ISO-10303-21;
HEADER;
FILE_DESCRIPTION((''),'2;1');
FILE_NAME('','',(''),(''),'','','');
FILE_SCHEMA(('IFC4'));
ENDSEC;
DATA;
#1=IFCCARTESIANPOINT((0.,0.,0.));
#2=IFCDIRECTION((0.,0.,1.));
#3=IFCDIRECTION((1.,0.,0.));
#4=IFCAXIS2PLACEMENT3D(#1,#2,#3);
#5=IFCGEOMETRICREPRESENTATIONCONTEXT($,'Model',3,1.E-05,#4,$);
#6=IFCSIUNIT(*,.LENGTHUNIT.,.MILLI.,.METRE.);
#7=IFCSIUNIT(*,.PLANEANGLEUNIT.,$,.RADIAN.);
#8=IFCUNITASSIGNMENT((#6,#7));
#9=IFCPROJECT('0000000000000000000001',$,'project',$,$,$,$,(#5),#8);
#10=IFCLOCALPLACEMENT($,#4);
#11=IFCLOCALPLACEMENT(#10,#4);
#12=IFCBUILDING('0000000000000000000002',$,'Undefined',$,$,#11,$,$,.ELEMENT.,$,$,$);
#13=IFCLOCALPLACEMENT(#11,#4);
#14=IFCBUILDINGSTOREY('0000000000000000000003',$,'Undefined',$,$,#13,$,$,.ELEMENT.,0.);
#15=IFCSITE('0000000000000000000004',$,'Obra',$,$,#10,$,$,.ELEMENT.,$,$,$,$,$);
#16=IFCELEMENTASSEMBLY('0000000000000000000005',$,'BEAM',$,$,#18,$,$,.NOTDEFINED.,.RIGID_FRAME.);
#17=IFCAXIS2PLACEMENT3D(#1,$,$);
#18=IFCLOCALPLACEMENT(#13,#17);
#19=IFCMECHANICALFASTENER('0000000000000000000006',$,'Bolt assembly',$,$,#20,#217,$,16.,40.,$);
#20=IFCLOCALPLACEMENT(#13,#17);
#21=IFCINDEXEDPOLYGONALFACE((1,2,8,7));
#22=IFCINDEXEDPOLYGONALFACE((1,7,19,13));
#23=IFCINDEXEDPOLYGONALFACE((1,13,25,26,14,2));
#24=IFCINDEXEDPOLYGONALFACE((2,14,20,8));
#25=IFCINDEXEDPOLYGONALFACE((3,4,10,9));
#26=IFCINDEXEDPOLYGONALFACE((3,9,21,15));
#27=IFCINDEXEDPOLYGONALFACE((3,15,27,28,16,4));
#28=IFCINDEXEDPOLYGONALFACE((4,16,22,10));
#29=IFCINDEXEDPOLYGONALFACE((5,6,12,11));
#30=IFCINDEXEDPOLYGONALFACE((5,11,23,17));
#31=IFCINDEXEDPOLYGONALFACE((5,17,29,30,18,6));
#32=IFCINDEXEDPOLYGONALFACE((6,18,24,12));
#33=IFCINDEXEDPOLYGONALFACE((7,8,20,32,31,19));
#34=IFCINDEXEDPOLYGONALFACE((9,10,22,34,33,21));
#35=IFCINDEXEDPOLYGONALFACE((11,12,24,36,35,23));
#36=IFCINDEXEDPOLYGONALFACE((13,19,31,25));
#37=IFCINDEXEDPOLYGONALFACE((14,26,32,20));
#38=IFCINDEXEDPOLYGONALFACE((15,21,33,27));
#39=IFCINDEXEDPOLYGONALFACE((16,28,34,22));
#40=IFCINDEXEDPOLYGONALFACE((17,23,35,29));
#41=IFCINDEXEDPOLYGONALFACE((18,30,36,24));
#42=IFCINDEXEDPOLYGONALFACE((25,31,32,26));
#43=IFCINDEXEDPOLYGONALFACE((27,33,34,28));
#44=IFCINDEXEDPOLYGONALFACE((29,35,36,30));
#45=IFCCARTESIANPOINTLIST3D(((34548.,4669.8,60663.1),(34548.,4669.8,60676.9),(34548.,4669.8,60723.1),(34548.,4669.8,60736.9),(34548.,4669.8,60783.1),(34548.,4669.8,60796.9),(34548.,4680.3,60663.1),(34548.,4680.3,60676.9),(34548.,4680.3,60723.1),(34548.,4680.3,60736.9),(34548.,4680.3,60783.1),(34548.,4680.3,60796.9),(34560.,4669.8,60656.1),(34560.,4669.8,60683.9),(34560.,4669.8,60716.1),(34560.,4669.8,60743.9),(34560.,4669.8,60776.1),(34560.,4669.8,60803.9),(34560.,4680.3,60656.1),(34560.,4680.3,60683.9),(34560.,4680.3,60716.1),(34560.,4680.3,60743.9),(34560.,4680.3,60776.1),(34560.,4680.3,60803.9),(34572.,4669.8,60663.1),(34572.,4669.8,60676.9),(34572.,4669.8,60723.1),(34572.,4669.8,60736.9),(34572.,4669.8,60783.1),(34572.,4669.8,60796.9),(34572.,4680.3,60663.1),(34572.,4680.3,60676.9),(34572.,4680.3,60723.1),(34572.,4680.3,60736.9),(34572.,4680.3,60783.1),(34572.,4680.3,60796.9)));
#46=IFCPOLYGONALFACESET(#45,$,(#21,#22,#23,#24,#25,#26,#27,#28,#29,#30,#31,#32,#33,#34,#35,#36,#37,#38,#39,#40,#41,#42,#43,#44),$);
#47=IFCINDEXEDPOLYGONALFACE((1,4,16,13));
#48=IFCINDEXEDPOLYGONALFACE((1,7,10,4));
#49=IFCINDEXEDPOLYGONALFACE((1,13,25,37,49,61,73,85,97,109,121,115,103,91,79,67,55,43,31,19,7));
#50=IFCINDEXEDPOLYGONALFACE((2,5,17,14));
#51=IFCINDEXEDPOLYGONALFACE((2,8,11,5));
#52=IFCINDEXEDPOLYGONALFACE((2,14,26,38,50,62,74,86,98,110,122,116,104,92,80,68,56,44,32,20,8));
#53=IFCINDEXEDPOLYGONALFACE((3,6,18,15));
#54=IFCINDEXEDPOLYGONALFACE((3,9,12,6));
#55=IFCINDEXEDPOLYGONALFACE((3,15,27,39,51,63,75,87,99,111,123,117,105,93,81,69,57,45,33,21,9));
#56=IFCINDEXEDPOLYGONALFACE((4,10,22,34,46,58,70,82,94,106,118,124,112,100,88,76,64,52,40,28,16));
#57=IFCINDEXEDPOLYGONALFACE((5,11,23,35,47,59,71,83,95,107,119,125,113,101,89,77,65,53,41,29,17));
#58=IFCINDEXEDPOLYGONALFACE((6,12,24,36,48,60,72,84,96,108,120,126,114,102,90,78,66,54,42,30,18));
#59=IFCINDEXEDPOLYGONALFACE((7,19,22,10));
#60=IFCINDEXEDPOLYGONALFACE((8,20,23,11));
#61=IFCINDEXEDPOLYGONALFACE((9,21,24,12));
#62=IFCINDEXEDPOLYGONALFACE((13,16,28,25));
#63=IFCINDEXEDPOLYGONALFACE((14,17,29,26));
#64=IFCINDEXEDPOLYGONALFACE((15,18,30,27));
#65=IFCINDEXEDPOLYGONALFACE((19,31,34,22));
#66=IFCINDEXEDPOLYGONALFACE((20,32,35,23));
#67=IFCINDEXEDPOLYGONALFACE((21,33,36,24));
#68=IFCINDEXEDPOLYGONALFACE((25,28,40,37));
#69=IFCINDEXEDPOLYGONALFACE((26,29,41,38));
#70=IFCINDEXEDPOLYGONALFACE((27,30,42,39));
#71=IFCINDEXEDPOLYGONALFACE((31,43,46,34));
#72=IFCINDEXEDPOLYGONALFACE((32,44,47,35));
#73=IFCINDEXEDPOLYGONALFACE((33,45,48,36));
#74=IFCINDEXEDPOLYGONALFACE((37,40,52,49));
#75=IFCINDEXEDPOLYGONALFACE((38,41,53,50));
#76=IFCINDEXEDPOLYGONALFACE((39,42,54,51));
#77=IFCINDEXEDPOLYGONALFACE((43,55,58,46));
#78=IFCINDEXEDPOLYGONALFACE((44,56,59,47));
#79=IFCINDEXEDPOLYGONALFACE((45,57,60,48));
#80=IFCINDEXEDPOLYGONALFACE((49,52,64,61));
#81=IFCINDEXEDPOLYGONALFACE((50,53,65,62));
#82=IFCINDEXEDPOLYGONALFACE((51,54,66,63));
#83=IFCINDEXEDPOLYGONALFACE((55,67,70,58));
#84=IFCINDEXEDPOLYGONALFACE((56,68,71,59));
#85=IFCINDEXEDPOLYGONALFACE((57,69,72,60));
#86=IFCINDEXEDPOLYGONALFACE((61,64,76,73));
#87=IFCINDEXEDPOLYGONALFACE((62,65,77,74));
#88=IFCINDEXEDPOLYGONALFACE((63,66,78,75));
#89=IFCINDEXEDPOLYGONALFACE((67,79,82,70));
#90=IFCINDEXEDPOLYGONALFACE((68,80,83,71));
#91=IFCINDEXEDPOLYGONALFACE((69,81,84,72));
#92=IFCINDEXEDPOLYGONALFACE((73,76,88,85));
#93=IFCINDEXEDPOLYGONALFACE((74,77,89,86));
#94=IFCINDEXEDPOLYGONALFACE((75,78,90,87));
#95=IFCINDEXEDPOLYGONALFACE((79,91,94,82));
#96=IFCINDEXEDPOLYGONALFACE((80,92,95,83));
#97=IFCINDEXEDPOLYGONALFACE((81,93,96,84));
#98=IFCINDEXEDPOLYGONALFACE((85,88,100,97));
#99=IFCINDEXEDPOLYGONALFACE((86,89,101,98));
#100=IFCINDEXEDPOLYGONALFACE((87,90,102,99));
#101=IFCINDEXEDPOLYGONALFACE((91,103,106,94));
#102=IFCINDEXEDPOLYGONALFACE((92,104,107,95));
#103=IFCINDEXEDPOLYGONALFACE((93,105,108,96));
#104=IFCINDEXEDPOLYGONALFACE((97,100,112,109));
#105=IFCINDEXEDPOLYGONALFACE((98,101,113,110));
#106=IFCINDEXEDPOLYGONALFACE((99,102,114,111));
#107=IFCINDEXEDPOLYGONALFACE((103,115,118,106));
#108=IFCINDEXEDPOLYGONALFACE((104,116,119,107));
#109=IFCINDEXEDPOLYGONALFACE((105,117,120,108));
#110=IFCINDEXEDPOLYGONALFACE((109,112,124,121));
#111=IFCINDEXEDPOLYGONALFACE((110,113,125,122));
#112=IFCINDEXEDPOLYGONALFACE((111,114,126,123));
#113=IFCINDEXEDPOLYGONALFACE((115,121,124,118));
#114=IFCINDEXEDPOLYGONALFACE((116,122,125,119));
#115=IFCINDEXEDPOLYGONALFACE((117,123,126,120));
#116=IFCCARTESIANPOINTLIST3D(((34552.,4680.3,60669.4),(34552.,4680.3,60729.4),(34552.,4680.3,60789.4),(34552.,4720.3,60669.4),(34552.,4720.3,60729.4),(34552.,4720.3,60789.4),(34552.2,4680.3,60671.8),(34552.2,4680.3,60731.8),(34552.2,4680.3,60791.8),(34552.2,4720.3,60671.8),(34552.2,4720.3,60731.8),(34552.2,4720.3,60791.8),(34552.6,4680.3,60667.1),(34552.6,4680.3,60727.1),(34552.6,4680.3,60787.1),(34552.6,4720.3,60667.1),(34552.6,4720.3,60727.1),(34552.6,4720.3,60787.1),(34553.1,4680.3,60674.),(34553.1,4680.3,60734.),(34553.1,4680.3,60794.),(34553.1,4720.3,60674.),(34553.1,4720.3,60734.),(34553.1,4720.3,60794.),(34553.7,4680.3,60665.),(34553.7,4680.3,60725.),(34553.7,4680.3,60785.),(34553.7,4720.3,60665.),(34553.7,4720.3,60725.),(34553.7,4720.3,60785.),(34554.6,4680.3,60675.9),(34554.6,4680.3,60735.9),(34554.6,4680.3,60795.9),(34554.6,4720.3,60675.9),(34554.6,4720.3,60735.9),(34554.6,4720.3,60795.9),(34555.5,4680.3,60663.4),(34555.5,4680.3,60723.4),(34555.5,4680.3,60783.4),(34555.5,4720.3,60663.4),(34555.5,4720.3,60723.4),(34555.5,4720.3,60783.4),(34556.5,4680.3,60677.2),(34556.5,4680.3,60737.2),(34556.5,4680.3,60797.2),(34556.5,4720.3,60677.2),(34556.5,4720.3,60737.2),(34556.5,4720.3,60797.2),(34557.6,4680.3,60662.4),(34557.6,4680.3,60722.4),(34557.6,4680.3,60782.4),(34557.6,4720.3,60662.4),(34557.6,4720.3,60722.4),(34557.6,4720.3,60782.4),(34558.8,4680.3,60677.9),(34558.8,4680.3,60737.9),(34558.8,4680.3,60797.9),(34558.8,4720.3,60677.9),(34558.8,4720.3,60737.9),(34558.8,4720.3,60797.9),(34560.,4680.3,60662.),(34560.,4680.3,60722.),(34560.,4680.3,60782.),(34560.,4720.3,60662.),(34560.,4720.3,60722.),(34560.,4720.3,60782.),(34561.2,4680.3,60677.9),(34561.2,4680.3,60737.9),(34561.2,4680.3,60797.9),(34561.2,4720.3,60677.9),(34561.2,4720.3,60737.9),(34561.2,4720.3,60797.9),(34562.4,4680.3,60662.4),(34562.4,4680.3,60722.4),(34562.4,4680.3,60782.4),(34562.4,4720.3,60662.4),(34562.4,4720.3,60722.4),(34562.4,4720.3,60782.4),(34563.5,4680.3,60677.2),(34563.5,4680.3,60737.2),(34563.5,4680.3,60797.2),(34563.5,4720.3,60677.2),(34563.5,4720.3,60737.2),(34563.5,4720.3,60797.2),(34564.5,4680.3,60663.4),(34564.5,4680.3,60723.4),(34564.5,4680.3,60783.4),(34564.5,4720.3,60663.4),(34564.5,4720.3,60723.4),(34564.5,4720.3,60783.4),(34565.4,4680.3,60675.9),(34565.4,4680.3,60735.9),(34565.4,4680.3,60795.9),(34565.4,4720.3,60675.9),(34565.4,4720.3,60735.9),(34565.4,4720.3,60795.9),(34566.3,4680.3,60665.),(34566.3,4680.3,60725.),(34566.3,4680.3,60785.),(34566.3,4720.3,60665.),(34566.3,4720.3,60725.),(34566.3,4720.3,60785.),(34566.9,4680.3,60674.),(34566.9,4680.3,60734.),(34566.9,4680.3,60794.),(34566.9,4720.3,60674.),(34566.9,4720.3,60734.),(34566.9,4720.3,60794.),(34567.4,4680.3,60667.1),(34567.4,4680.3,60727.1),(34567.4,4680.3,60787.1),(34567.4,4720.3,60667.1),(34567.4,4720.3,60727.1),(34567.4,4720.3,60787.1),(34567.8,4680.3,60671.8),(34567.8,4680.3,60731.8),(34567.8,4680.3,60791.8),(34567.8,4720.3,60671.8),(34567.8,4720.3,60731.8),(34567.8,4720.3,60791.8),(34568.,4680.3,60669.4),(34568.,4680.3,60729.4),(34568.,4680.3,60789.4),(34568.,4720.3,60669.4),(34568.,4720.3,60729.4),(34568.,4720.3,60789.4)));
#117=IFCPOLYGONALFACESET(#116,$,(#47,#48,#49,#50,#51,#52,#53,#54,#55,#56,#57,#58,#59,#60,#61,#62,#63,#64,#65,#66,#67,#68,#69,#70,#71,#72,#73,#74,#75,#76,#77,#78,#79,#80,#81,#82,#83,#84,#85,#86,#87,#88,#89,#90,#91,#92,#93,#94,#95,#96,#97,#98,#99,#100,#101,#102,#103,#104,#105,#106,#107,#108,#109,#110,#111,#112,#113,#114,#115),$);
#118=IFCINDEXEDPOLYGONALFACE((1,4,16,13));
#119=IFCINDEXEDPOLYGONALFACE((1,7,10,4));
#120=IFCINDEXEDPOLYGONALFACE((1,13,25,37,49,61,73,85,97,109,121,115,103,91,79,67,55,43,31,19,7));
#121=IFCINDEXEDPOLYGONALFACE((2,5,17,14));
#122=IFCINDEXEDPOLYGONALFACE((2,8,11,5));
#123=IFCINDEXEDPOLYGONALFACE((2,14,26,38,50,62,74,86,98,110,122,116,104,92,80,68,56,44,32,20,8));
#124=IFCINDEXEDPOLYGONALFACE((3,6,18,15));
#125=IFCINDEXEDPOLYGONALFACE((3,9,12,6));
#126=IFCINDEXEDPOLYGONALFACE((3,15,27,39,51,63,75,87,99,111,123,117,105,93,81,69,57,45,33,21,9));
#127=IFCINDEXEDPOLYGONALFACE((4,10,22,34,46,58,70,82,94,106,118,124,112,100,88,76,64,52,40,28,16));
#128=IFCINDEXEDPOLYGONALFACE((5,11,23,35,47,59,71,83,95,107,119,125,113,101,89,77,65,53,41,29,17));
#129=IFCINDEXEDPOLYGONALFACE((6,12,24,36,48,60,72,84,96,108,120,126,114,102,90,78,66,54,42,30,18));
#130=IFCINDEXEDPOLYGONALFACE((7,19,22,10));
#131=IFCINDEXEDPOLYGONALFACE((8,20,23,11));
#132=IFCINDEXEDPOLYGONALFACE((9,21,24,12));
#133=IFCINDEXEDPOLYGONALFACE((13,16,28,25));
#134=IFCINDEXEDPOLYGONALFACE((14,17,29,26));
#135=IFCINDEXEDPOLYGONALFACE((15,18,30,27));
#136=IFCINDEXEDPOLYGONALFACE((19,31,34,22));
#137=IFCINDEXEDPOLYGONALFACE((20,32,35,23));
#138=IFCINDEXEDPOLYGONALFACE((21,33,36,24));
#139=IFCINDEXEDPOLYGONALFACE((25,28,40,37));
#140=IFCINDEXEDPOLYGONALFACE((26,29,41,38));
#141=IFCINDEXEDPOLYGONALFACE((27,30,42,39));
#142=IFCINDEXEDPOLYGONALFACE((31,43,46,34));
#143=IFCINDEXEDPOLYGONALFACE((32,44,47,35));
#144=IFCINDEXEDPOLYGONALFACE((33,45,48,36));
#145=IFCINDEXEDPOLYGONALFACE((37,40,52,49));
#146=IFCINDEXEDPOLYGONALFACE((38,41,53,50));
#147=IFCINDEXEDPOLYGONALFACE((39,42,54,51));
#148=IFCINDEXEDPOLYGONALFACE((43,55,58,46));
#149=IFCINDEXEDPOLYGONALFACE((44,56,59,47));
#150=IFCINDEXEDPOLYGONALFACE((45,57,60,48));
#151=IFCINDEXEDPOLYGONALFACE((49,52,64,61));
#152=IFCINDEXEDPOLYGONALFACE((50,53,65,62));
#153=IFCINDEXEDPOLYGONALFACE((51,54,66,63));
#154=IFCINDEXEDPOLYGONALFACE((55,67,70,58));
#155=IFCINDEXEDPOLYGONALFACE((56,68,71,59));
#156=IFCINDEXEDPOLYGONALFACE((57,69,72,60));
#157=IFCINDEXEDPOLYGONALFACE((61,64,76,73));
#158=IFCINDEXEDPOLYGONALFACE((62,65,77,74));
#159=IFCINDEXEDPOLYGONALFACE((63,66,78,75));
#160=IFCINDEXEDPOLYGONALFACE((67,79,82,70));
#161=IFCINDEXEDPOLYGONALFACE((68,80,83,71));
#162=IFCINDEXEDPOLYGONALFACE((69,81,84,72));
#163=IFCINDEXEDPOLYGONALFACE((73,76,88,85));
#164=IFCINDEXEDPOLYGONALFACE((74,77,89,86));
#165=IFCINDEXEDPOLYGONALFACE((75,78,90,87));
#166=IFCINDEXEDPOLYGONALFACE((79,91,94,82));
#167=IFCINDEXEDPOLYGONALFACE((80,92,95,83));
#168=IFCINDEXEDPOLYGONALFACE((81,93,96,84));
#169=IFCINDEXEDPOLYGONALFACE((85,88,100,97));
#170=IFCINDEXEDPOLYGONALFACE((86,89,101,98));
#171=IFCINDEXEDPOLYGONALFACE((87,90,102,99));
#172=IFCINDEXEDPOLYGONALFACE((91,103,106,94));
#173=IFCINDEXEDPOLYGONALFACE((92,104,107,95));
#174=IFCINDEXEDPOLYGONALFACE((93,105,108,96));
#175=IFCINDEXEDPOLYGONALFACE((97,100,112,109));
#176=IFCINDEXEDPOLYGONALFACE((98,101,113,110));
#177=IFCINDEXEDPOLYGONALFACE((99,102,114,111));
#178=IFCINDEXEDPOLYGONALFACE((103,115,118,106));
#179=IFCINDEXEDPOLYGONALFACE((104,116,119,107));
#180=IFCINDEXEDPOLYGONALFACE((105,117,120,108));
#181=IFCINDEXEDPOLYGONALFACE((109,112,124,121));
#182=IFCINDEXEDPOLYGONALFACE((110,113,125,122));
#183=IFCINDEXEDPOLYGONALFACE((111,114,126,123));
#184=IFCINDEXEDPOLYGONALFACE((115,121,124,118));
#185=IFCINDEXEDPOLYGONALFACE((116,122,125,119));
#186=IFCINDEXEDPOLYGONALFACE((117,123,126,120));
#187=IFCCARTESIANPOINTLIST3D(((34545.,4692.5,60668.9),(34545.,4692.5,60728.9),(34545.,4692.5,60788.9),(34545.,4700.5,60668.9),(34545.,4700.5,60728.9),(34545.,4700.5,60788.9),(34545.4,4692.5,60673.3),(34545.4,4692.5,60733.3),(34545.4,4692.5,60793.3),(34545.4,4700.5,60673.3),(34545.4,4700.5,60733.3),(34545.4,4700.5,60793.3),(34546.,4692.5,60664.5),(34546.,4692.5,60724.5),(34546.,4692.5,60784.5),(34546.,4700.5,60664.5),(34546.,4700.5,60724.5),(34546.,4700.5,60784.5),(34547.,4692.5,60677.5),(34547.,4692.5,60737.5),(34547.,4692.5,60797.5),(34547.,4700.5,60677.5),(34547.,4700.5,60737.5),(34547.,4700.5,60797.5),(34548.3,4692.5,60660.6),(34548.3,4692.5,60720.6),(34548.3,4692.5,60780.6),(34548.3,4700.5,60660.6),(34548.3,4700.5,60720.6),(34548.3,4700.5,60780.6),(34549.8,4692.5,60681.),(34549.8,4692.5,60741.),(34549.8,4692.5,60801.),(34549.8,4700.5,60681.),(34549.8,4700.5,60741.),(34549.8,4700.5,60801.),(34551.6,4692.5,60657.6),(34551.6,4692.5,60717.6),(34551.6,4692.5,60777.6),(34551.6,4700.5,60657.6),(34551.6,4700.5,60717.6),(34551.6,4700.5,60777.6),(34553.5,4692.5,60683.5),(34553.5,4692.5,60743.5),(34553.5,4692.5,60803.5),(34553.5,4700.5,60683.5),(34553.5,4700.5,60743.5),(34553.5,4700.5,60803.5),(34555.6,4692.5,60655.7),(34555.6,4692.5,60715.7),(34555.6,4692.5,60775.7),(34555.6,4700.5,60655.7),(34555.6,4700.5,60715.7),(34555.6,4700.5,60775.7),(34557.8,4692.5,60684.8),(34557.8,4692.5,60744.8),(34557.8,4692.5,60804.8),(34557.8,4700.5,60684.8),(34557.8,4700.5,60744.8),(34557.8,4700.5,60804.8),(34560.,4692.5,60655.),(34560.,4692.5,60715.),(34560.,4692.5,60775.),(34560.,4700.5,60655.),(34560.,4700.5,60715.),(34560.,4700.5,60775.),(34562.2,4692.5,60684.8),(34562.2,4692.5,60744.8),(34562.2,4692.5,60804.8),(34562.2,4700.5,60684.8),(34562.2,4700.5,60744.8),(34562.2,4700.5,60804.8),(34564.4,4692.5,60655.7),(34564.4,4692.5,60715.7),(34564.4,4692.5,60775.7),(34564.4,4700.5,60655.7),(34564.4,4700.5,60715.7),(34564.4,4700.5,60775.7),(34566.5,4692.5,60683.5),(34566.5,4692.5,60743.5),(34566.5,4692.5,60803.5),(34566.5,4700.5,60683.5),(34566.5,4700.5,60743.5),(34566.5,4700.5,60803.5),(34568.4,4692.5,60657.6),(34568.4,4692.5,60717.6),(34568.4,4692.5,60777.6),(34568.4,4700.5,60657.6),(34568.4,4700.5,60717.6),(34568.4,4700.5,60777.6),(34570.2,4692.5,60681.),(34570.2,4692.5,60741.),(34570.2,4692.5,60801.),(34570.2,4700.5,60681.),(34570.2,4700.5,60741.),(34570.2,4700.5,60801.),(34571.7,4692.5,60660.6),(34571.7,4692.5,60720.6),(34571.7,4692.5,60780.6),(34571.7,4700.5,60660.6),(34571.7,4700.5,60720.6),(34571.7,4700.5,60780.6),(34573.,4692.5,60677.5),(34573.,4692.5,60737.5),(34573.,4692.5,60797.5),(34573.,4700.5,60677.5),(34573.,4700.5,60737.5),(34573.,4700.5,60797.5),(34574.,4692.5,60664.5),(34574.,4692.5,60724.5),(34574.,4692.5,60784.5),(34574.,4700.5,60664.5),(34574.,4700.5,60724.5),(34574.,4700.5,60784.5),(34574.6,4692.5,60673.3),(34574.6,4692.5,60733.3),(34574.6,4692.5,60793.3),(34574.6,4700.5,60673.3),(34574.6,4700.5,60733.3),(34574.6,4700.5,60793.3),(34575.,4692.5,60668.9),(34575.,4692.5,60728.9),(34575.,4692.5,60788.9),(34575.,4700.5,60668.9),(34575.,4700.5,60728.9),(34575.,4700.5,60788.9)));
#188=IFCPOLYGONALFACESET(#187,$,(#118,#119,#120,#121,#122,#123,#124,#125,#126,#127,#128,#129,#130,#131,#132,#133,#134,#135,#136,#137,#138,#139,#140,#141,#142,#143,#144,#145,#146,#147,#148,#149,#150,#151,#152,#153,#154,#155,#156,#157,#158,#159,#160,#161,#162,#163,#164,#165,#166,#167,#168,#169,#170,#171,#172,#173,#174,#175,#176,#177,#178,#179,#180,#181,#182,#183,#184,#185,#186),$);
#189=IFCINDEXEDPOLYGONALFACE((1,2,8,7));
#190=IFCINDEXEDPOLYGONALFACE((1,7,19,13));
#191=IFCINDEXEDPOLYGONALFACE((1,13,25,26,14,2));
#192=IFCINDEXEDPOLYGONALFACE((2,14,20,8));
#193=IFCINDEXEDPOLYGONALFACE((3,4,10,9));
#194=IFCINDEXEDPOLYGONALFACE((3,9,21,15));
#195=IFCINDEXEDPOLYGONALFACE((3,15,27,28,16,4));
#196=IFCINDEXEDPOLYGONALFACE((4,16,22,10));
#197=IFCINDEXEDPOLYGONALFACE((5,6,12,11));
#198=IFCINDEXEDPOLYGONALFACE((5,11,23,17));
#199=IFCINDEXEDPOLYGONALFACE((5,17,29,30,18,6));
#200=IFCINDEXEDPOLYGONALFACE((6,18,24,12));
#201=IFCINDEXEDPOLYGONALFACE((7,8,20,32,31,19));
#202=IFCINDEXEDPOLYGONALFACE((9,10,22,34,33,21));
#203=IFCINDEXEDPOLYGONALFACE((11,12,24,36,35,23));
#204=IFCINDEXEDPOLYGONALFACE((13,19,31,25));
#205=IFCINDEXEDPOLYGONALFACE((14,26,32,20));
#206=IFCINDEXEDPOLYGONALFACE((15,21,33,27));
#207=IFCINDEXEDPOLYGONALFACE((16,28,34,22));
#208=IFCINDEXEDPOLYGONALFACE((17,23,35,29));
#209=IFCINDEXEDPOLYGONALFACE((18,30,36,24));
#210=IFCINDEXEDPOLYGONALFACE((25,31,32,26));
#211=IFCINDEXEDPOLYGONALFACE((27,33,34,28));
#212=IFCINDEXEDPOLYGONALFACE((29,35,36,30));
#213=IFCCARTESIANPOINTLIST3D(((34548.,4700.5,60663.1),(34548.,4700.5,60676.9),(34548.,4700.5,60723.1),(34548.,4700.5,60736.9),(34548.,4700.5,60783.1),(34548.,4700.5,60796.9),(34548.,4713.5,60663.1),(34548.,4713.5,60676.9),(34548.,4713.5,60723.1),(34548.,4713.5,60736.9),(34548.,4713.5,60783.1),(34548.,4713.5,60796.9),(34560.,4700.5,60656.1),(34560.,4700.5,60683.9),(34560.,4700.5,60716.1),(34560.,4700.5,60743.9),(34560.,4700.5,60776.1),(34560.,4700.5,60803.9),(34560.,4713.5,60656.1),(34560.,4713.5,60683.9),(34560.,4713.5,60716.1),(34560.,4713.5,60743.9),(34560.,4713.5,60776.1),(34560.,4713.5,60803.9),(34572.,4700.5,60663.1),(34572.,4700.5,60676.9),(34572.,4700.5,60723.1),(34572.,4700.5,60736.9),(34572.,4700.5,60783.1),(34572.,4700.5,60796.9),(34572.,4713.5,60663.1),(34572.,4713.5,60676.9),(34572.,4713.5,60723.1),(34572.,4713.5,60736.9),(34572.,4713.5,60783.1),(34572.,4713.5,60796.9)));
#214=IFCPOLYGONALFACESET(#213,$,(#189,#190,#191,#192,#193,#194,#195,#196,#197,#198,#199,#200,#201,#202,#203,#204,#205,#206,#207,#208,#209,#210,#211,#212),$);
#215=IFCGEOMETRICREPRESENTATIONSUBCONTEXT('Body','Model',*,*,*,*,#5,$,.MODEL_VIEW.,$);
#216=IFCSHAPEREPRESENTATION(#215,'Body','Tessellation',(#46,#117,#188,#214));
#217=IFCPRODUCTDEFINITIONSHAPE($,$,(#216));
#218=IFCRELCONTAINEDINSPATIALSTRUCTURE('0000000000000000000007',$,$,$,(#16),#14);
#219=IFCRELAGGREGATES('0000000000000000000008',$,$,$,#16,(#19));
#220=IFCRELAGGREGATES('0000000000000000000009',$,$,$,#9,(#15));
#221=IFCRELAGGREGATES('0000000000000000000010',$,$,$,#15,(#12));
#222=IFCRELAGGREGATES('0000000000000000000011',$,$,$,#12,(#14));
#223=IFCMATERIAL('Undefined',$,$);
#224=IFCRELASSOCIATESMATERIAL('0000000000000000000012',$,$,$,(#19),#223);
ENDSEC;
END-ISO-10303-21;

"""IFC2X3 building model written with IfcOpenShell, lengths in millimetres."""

from ifc_helpers import new_model, si_unit, frame, origin_with_axes, origin_2d_with_axis, place, context, subcontext, project, spatial, polyline, circle, outline, extrude, source, transform, mapped, material, element, aggregate, save


model = new_model("IFC2X3")

# Units and contexts
model_context = context("Model", 3, precision=1e-05, world=origin_with_axes())
body_context = subcontext(model_context, "Body", "Model", "MODEL_VIEW")
ifc_project = project(units=[si_unit("LENGTHUNIT", "METRE", prefix="MILLI"), si_unit("PLANEANGLEUNIT", "RADIAN")], contexts=[model_context])

# Site, building, storey
site_placement = place(None, origin_with_axes())
site = spatial("IfcSite", under=ifc_project, at=site_placement, Name="Obra", CompositionType="ELEMENT")
building_placement = place(site_placement, origin_with_axes())
building = spatial("IfcBuilding", under=site, at=building_placement, Name="Undefined", CompositionType="ELEMENT")
storey_placement = place(building_placement, origin_with_axes())
storey = spatial("IfcBuildingStorey", under=building, at=storey_placement, Name="Undefined", CompositionType="ELEMENT", Elevation=0.0)

# Shared definitions
ifc_material_1 = material(Name="Undefined")

# Element assembly, mechanical fastener
assembly_1_placement = place(storey_placement, origin_with_axes())
assembly_1 = element("IfcElementAssembly", 1, at=assembly_1_placement, inside=storey, Name="BEAM", AssemblyPlace="NOTDEFINED", PredefinedType="RIGID_FRAME")
shared_shape_1 = source(origin_with_axes(), body_context, "Body", "SweptSolid", [
    extrude(outline(polyline([(13.9, 0.0), (6.9, 12.0), (-6.9, 12.0), (-13.9, 0.0), (-6.9, -12.0), (6.9, -12.0), (13.9, 0.0)])), frame((0.0, -19.7, 0.0), z_axis=(0.0, 1.0, 0.0), x_axis=(1.0, 0.0, 0.0)), (0.0, 0.0, 1.0), 10.6),
    extrude(circle(Radius=8.0, at=origin_2d_with_axis()), frame((0.0, -9.1, 0.0), z_axis=(0.0, 1.0, 0.0), x_axis=(1.0, 0.0, 0.0)), (0.0, 0.0, 1.0), 40.0),
    extrude(circle(Radius=15.0, at=origin_2d_with_axis()), frame((0.0, 3.1, 0.0), z_axis=(0.0, 1.0, 0.0), x_axis=(1.0, 0.0, 0.0)), (0.0, 0.0, 1.0), 8.0),
    extrude(outline(polyline([(13.9, 0.0), (6.9, 12.0), (-6.9, 12.0), (-13.9, 0.0), (-6.9, -12.0), (6.9, -12.0), (13.9, 0.0)])), frame((0.0, 11.1, 0.0), z_axis=(0.0, 1.0, 0.0), x_axis=(1.0, 0.0, 0.0)), (0.0, 0.0, 1.0), 13.0),
])
mechanical_fastener_1_placement = place(assembly_1_placement, frame((34510.0, 4689.4, 60850.0), z_axis=(1.0, 0.0, 0.0), x_axis=(0.0, 0.0, -1.0)))
mechanical_fastener_1 = element("IfcMechanicalFastener", 2, at=mechanical_fastener_1_placement, material=ifc_material_1, Name="Bolt assembly", NominalDiameter=16.0, NominalLength=40.0, context=body_context, shape_type="MappedRepresentation", body=[
    mapped(shared_shape_1, transform((60.0, 0.0, 50.0))),
    mapped(shared_shape_1, transform((120.0, 0.0, 50.0))),
    mapped(shared_shape_1, transform((180.0, 0.0, 50.0))),
])
aggregate(assembly_1, [mechanical_fastener_1])

save(model, "model.ifc")
